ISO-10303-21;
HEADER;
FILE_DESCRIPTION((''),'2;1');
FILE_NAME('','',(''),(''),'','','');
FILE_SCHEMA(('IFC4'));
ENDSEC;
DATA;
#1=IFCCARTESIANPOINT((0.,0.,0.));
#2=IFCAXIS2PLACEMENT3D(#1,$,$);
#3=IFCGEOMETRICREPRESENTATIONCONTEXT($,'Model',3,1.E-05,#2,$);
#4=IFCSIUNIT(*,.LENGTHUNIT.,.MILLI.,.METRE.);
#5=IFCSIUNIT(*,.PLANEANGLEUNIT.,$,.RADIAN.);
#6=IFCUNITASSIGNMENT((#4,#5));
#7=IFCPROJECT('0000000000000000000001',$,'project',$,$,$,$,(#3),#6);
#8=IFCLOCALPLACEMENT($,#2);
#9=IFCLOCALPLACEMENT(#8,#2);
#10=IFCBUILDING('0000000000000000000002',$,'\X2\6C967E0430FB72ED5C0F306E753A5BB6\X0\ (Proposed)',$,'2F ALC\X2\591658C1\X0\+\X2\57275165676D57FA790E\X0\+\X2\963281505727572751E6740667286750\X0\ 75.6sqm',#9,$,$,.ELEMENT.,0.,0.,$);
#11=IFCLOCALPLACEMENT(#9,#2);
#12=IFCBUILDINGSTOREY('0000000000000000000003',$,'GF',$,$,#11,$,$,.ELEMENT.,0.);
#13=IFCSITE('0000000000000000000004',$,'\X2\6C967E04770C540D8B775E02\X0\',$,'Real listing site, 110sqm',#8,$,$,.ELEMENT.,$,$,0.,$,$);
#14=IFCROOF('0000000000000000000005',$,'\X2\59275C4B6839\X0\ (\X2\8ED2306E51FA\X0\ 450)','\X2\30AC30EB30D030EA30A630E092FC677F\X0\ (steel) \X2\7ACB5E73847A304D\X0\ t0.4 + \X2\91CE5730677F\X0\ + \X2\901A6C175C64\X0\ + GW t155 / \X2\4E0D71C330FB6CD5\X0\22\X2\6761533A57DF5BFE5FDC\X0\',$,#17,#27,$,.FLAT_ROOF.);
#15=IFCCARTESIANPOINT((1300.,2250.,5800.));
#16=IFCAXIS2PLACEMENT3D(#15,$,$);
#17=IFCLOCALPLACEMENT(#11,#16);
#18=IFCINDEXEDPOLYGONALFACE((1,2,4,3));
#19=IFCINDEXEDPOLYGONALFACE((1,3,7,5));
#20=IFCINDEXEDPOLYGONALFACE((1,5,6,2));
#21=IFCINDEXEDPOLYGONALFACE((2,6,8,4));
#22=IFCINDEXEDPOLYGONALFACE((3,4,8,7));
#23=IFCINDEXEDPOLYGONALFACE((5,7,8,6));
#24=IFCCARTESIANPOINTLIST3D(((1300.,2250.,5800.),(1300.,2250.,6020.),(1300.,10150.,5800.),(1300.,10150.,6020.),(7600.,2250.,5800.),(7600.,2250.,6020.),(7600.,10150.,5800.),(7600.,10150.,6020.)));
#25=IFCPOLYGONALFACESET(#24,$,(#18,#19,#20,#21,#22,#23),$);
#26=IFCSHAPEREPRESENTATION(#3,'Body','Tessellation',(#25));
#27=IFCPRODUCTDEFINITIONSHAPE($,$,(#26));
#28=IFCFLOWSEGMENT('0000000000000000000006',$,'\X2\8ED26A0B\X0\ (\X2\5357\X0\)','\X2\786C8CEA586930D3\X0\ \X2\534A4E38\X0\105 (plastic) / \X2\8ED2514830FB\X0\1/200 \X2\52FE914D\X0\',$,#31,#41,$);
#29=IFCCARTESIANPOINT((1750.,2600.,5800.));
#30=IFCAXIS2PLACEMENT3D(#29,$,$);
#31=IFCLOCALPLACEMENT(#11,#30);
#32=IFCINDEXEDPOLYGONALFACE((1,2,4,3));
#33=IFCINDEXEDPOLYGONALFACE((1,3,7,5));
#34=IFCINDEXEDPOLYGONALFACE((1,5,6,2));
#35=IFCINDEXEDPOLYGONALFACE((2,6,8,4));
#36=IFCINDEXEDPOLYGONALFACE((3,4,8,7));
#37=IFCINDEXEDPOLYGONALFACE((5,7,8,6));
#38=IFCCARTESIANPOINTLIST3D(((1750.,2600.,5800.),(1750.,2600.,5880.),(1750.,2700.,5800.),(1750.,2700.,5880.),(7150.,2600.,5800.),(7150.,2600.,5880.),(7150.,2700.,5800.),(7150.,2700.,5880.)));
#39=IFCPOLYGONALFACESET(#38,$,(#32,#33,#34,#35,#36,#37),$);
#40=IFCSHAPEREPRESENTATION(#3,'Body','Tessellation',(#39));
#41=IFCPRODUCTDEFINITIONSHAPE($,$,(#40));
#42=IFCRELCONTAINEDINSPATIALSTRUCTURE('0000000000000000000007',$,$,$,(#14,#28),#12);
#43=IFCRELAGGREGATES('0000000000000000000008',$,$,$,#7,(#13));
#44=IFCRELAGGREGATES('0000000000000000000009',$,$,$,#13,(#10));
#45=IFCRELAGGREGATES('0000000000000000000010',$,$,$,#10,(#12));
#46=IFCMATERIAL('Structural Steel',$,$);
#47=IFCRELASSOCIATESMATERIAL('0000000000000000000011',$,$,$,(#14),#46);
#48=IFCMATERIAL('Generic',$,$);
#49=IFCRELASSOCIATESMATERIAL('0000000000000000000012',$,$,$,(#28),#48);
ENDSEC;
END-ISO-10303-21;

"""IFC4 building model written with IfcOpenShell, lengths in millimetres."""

from ifc_helpers import new_model, si_unit, frame, frame_2d, origin, place, context, project, spatial, rectangle, extrude, material, element, save


model = new_model("IFC4")

# Units and contexts
model_context = context("Model", 3, precision=1e-05, world=origin())
ifc_project = project(units=[si_unit("LENGTHUNIT", "METRE", prefix="MILLI"), si_unit("PLANEANGLEUNIT", "RADIAN")], contexts=[model_context])

# Site, building, storey
site_placement = place(None, origin())
site = spatial("IfcSite", under=ifc_project, at=site_placement, Name="沖縄県名護市", ObjectType="Real listing site, 110sqm", CompositionType="ELEMENT", RefElevation=0.0)
building_placement = place(site_placement, origin())
building = spatial("IfcBuilding", under=site, at=building_placement, Name="沖縄・狭小の町家 (Proposed)", ObjectType="2F ALC外壁+圧入杭基礎+防腐圧圧処理木材 75.6sqm", CompositionType="ELEMENT", ElevationOfRefHeight=0.0, ElevationOfTerrain=0.0)
storey_placement = place(building_placement, origin())
storey = spatial("IfcBuildingStorey", under=building, at=storey_placement, Name="GF", CompositionType="ELEMENT", Elevation=0.0)

# Roof
ifc_material_1 = material(Name="Structural Steel")
roof_placement = place(storey_placement, frame((1300.0, 2250.0, 5800.0)))
element("IfcRoof", 1, at=roof_placement, inside=storey, material=ifc_material_1, Name="大屋根 (軒の出 450)", Description="ガルバリウム鋼板 (steel) 立平葺き t0.4 + 野地板 + 通気層 + GW t155 / 不燃・法22条区域対応", PredefinedType="FLAT_ROOF", context=model_context, shape_type="SweptSolid", body=[
    extrude(rectangle(XDim=6300.0, YDim=7900.0, at=frame_2d((3150.0, 3950.0))), frame((1300.0, 2250.0, 5800.0)), (0.0, 0.0, 1.0), 220.0),
])

# Flow segment
ifc_material_2 = material(Name="Generic")
flow_segment_placement = place(storey_placement, frame((1750.0, 2600.0, 5800.0)))
element("IfcFlowSegment", 2, at=flow_segment_placement, inside=storey, material=ifc_material_2, Name="軒樋 (南)", Description="硬質塩ビ 半丸105 (plastic) / 軒先・1/200 勾配", context=model_context, shape_type="SweptSolid", body=[
    extrude(rectangle(XDim=5400.0, YDim=100.0, at=frame_2d((2700.0, 50.0))), frame((1750.0, 2600.0, 5800.0)), (0.0, 0.0, 1.0), 80.0),
])

save(model, "model.ifc")
